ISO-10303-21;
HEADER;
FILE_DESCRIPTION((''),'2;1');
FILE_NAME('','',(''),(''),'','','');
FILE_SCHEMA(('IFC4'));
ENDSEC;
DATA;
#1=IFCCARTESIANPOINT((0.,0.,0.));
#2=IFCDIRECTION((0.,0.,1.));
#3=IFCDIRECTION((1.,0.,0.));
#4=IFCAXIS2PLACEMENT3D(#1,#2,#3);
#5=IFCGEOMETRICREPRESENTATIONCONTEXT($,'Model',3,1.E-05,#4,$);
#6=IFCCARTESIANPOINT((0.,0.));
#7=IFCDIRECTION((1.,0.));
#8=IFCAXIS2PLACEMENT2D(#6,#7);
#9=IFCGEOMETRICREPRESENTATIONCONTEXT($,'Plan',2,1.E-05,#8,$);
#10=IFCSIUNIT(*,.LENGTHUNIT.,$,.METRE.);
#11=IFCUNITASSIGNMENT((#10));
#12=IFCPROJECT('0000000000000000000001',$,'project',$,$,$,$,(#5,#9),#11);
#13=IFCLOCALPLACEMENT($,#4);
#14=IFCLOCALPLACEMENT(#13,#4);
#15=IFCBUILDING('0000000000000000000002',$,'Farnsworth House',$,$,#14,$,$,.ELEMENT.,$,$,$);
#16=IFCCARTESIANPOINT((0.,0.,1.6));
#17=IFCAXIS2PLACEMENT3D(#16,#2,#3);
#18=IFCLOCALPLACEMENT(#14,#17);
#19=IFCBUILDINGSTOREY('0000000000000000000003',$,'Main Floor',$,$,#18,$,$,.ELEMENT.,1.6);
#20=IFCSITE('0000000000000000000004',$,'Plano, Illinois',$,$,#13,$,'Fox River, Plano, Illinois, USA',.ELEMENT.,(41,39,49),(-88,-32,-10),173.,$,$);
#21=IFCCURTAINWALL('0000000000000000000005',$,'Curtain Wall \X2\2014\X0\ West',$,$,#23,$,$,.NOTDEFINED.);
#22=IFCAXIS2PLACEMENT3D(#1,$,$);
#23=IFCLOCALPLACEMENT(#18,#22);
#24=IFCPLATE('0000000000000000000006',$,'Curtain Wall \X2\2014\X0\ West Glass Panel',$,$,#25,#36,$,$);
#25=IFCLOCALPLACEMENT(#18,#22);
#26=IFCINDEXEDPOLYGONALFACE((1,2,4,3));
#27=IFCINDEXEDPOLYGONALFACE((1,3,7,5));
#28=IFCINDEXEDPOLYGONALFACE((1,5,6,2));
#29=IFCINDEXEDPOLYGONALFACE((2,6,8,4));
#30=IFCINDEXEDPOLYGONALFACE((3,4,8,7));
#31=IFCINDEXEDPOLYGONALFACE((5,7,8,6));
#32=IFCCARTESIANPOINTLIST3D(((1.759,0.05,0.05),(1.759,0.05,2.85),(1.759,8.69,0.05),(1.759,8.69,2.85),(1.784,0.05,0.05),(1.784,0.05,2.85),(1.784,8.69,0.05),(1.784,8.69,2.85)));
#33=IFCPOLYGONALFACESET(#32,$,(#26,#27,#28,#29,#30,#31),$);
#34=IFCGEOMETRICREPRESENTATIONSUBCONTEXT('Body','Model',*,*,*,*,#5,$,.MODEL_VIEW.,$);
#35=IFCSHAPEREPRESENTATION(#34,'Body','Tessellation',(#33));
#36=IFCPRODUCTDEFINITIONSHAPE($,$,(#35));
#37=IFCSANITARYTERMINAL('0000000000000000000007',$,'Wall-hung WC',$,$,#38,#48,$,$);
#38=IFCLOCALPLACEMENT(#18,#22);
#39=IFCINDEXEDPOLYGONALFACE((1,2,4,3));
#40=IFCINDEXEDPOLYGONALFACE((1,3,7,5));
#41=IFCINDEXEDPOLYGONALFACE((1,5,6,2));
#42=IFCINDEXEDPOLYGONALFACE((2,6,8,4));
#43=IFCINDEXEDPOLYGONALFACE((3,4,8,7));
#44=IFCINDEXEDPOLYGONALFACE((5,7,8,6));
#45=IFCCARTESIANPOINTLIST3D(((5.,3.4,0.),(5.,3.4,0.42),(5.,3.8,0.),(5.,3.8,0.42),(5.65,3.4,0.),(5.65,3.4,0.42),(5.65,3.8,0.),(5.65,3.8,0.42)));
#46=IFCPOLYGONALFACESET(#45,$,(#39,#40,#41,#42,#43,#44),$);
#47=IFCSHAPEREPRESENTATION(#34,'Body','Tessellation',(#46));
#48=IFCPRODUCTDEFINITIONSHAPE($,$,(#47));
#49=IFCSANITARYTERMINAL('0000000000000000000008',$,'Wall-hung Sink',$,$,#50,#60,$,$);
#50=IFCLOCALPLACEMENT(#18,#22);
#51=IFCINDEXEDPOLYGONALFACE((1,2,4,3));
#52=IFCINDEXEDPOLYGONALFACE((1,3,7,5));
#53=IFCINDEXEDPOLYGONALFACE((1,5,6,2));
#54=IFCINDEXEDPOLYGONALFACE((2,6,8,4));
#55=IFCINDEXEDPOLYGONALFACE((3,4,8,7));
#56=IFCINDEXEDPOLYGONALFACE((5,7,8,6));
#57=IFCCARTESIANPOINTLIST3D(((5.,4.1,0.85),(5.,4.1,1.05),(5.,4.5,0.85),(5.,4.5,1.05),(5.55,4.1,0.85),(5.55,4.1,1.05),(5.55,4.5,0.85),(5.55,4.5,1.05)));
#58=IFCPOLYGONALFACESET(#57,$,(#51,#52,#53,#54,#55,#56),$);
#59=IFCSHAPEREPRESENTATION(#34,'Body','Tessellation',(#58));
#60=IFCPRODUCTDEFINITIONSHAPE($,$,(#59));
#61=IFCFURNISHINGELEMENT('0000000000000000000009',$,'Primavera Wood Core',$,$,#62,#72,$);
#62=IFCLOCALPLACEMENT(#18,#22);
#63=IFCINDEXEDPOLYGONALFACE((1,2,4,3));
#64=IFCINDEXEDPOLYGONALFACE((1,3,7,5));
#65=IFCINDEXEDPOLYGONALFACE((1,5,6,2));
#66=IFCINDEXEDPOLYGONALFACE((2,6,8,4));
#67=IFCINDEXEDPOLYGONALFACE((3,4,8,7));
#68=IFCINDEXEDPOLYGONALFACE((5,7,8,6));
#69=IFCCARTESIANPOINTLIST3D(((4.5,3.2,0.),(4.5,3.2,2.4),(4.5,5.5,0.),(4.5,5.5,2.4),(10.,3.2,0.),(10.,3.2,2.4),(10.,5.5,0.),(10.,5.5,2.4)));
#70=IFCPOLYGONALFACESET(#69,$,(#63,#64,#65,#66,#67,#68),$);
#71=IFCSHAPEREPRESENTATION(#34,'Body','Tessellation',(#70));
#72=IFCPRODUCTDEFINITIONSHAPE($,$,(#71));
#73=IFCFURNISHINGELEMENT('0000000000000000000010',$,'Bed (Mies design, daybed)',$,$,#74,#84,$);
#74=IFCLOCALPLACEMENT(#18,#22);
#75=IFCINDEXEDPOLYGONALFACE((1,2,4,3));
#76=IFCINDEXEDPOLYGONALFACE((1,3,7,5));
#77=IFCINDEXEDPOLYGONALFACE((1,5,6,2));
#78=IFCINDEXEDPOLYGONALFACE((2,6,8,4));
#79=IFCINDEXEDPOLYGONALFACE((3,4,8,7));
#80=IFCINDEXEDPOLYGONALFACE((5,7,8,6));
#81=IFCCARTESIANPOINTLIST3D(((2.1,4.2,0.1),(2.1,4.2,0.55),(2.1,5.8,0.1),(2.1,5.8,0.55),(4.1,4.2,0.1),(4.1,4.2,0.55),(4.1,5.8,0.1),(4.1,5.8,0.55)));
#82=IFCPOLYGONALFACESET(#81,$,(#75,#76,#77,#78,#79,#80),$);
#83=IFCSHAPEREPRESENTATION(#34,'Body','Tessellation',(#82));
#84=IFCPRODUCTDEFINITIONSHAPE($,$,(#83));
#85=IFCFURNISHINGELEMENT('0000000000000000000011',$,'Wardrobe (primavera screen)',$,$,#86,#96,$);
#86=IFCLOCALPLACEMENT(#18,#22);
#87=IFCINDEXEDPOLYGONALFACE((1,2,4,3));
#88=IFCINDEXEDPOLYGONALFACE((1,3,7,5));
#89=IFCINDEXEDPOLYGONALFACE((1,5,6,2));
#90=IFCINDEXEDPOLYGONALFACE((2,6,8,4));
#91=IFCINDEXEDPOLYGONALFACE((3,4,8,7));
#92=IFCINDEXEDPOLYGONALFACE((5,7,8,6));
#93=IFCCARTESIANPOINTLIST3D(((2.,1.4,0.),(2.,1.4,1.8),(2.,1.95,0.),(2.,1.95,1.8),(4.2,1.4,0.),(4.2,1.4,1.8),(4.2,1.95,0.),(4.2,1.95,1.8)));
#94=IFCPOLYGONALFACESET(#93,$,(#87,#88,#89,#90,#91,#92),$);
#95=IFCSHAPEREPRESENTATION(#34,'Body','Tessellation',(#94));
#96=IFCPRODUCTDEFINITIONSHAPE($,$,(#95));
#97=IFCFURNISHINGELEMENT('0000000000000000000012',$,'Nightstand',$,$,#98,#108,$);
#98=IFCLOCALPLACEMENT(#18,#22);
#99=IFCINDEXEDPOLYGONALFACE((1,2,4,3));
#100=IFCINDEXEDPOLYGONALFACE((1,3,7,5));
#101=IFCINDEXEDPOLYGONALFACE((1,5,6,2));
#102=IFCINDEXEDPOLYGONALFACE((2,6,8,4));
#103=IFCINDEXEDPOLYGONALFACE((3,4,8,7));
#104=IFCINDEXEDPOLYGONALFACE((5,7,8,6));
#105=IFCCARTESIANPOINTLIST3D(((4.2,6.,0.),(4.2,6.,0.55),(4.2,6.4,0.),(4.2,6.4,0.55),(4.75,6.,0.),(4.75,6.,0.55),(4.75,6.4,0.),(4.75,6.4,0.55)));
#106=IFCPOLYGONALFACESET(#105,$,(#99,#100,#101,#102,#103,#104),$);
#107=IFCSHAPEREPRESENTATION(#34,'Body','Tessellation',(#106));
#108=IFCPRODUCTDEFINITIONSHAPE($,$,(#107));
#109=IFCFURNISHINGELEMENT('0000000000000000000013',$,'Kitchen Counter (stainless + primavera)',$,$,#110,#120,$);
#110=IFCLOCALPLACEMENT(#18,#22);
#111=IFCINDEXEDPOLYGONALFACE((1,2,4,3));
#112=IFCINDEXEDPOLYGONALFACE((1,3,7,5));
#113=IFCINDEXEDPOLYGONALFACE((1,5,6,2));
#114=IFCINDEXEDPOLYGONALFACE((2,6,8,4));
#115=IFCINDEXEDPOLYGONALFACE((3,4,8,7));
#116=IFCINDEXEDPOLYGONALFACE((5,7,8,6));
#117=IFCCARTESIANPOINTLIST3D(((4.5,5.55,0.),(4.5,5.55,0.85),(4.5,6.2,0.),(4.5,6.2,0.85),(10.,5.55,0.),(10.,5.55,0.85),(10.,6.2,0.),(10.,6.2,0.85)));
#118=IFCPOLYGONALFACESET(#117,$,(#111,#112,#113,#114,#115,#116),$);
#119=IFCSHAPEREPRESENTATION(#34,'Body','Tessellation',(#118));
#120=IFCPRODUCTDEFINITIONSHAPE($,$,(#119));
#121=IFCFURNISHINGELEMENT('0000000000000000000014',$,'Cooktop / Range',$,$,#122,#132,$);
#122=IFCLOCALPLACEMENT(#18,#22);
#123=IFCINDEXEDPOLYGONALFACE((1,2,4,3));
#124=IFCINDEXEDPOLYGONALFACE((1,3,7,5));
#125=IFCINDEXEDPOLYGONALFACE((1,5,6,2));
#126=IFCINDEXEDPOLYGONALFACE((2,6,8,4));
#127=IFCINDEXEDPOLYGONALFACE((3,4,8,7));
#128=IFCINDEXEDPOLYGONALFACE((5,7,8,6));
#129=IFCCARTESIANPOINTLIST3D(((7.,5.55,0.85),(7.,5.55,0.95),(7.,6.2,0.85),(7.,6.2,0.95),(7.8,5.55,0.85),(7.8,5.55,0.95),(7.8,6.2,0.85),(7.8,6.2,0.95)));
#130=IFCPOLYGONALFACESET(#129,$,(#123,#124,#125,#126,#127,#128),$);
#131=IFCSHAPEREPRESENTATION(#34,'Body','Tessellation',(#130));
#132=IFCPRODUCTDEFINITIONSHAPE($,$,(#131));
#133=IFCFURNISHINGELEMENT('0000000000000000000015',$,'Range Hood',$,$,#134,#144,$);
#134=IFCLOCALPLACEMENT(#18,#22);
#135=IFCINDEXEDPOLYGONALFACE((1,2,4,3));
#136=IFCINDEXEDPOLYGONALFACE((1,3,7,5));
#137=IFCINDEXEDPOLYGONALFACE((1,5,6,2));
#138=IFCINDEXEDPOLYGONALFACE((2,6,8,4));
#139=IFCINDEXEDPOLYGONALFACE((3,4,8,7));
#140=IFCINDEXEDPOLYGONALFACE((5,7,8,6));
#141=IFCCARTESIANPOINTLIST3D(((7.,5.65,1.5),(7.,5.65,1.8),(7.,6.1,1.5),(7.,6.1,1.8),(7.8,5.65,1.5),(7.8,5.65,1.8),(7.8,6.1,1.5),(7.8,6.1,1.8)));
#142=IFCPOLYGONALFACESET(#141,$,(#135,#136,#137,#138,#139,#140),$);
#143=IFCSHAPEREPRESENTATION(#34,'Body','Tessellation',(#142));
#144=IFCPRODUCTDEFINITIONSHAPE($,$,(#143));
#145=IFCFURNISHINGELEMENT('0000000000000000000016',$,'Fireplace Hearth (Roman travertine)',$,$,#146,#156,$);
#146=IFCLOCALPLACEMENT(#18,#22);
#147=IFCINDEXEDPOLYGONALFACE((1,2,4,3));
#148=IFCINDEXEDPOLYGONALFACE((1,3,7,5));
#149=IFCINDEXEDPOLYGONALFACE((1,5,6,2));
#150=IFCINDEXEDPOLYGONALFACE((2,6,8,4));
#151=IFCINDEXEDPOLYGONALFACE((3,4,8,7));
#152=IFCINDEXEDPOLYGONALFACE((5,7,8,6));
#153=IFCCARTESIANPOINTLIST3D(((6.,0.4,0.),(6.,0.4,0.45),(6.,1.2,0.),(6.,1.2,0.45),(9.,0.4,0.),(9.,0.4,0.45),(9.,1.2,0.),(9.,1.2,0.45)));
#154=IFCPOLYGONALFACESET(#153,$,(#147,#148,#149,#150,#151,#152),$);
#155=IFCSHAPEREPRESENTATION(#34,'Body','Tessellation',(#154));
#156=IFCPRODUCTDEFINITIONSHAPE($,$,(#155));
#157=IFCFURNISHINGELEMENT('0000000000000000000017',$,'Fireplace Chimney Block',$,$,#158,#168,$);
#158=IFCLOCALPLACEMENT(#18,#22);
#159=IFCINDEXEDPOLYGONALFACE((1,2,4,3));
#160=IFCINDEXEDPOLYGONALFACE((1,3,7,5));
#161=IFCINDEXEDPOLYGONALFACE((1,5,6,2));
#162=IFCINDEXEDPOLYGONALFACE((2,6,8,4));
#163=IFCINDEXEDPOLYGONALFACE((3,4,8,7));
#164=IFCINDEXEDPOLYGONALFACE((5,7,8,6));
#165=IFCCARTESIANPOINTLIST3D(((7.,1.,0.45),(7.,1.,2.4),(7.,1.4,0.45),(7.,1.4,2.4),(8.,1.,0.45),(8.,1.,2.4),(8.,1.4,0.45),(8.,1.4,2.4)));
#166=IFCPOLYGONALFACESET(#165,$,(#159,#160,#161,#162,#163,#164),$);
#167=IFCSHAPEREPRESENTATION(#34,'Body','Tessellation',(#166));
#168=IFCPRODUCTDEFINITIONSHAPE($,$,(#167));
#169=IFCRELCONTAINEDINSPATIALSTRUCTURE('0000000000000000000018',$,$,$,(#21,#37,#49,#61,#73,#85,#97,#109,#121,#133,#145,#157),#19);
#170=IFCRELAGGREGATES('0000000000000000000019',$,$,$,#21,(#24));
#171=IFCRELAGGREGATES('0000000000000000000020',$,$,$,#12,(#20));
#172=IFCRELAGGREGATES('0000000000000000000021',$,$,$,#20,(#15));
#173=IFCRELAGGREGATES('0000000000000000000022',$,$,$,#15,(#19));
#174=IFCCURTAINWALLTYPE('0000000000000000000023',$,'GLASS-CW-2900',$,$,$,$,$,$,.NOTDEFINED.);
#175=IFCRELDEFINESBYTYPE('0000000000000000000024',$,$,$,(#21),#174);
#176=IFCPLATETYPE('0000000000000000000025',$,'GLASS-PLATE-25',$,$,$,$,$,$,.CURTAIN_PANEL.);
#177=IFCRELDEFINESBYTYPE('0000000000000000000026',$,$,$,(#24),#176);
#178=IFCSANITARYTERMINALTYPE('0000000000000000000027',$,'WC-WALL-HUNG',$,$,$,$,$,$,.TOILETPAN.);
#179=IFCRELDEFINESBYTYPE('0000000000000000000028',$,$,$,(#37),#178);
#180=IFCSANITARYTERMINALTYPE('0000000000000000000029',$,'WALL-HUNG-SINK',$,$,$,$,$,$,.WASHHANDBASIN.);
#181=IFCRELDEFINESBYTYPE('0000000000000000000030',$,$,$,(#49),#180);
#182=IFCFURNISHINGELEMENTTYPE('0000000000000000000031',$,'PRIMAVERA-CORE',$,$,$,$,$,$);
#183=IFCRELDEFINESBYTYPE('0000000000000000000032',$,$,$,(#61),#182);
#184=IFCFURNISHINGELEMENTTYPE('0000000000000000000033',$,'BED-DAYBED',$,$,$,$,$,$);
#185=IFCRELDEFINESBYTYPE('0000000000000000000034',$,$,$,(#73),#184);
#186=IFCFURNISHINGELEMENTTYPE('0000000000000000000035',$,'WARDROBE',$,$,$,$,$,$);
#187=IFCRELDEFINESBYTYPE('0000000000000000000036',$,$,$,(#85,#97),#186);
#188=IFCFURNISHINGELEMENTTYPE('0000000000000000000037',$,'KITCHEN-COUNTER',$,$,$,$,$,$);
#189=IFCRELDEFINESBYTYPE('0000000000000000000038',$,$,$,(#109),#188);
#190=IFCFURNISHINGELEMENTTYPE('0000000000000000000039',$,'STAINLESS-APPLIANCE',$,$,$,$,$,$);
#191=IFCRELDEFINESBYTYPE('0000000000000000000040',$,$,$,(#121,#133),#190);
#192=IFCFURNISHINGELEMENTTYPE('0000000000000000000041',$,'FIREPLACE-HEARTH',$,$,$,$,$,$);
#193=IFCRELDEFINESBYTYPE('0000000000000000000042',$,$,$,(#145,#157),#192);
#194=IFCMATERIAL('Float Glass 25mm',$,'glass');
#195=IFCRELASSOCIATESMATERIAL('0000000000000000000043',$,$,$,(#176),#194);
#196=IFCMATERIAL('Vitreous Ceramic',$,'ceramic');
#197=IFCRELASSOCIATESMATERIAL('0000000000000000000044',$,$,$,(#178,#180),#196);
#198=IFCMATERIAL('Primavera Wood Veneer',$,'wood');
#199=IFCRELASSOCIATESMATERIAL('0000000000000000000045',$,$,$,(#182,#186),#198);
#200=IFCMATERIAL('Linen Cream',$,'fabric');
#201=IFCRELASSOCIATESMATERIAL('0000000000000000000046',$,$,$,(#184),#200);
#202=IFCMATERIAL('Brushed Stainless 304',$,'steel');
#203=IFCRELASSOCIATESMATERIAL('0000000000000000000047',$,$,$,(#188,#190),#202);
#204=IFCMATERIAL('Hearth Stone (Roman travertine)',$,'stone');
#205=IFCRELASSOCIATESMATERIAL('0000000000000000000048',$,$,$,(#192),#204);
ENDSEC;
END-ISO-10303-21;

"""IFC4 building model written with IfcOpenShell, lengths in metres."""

from ifc_helpers import new_model, si_unit, frame, origin_with_axes, origin_2d_with_axis, place, context, subcontext, project, spatial, rectangle, extrude, material, type_object, element, aggregate, save


model = new_model("IFC4")

# Units and contexts
model_context = context("Model", 3, precision=1e-05, world=origin_with_axes())
plan_context = context("Plan", 2, precision=1e-05, world=origin_2d_with_axis())
body_context = subcontext(model_context, "Body", "Model", "MODEL_VIEW")
ifc_project = project(units=[si_unit("LENGTHUNIT", "METRE")], contexts=[model_context, plan_context])

# Site, building, storey
site_placement = place(None, origin_with_axes())
site = spatial("IfcSite", under=ifc_project, at=site_placement, Name="Plano, Illinois", LongName="Fox River, Plano, Illinois, USA", CompositionType="ELEMENT", RefLatitude=(41, 39, 49), RefLongitude=(-88, -32, -10), RefElevation=173.0)
building_placement = place(site_placement, origin_with_axes())
building = spatial("IfcBuilding", under=site, at=building_placement, Name="Farnsworth House", CompositionType="ELEMENT")
storey_placement = place(building_placement, frame((0.0, 0.0, 1.6), z_axis=(0.0, 0.0, 1.0), x_axis=(1.0, 0.0, 0.0)))
storey = spatial("IfcBuildingStorey", under=building, at=storey_placement, Name="Main Floor", CompositionType="ELEMENT", Elevation=1.6)

# Curtain wall
curtain_wall_type = type_object("IfcCurtainWallType", Name="GLASS-CW-2900", PredefinedType="NOTDEFINED")
curtain_wall_1_placement = place(storey_placement, frame((1.7839, 0.0, 0.0), z_axis=(0.0, 0.0, 1.0), x_axis=(0.0, 1.0, 0.0)))
curtain_wall_1 = element("IfcCurtainWall", 1, at=curtain_wall_1_placement, inside=storey, type_object=curtain_wall_type, Name="Curtain Wall — West", PredefinedType="NOTDEFINED")

# Plate
ifc_material_1 = material(Name="Float Glass 25mm", Category="glass")
plate_type = type_object("IfcPlateType", Name="GLASS-PLATE-25", PredefinedType="CURTAIN_PANEL", material=ifc_material_1)
plate_1_placement = place(curtain_wall_1_placement, frame((0.05, 0.0, 0.05), z_axis=(0.0, 0.0, 1.0), x_axis=(1.0, 0.0, 0.0)))
plate_1 = element("IfcPlate", 2, at=plate_1_placement, type_object=plate_type, Name="Curtain Wall — West Glass Panel", context=body_context, shape_type="SweptSolid", body=[
    extrude(rectangle(XDim=8.64, YDim=0.025, at=origin_2d_with_axis()), frame((4.32, 0.0125, 0.0), z_axis=(0.0, 0.0, 1.0), x_axis=(1.0, 0.0, 0.0)), (0.0, 0.0, 1.0), 2.8),
])
aggregate(curtain_wall_1, [plate_1])

# Sanitary terminals
ifc_material_2 = material(Name="Vitreous Ceramic", Category="ceramic")
sanitary_terminal_type_1 = type_object("IfcSanitaryTerminalType", Name="WC-WALL-HUNG", PredefinedType="TOILETPAN", material=ifc_material_2)
sanitary_terminal_1_placement = place(storey_placement, frame((5.0, 3.4, 0.0), z_axis=(0.0, 0.0, 1.0), x_axis=(1.0, 0.0, 0.0)))
element("IfcSanitaryTerminal", 3, at=sanitary_terminal_1_placement, inside=storey, type_object=sanitary_terminal_type_1, Name="Wall-hung WC", context=body_context, shape_type="SweptSolid", body=[
    extrude(rectangle(XDim=0.65, YDim=0.4, at=origin_2d_with_axis()), frame((0.325, 0.2, 0.0), z_axis=(0.0, 0.0, 1.0), x_axis=(1.0, 0.0, 0.0)), (0.0, 0.0, 1.0), 0.42),
])
sanitary_terminal_type_2 = type_object("IfcSanitaryTerminalType", Name="WALL-HUNG-SINK", PredefinedType="WASHHANDBASIN", material=ifc_material_2)
sanitary_terminal_2_placement = place(storey_placement, frame((5.0, 4.1, 0.85), z_axis=(0.0, 0.0, 1.0), x_axis=(1.0, 0.0, 0.0)))
element("IfcSanitaryTerminal", 4, at=sanitary_terminal_2_placement, inside=storey, type_object=sanitary_terminal_type_2, Name="Wall-hung Sink", context=body_context, shape_type="SweptSolid", body=[
    extrude(rectangle(XDim=0.55, YDim=0.4, at=origin_2d_with_axis()), frame((0.275, 0.2, 0.0), z_axis=(0.0, 0.0, 1.0), x_axis=(1.0, 0.0, 0.0)), (0.0, 0.0, 1.0), 0.2),
])

# Furnishing elements
ifc_material_3 = material(Name="Primavera Wood Veneer", Category="wood")
furnishing_element_type_1 = type_object("IfcFurnishingElementType", Name="PRIMAVERA-CORE", material=ifc_material_3)
furnishing_1_placement = place(storey_placement, frame((4.5, 3.2, 0.0), z_axis=(0.0, 0.0, 1.0), x_axis=(1.0, 0.0, 0.0)))
element("IfcFurnishingElement", 5, at=furnishing_1_placement, inside=storey, type_object=furnishing_element_type_1, Name="Primavera Wood Core", context=body_context, shape_type="SweptSolid", body=[
    extrude(rectangle(XDim=5.5, YDim=2.3, at=origin_2d_with_axis()), frame((2.75, 1.15, 0.0), z_axis=(0.0, 0.0, 1.0), x_axis=(1.0, 0.0, 0.0)), (0.0, 0.0, 1.0), 2.4),
])
ifc_material_4 = material(Name="Linen Cream", Category="fabric")
furnishing_element_type_2 = type_object("IfcFurnishingElementType", Name="BED-DAYBED", material=ifc_material_4)
furnishing_2_placement = place(storey_placement, frame((2.1, 4.2, 0.1), z_axis=(0.0, 0.0, 1.0), x_axis=(1.0, 0.0, 0.0)))
element("IfcFurnishingElement", 6, at=furnishing_2_placement, inside=storey, type_object=furnishing_element_type_2, Name="Bed (Mies design, daybed)", context=body_context, shape_type="SweptSolid", body=[
    extrude(rectangle(XDim=2.0, YDim=1.6, at=origin_2d_with_axis()), frame((1.0, 0.8, 0.0), z_axis=(0.0, 0.0, 1.0), x_axis=(1.0, 0.0, 0.0)), (0.0, 0.0, 1.0), 0.45),
])
furnishing_element_type_3 = type_object("IfcFurnishingElementType", Name="WARDROBE", material=ifc_material_3)
furnishing_3_placement = place(storey_placement, frame((2.0, 1.4, 0.0), z_axis=(0.0, 0.0, 1.0), x_axis=(1.0, 0.0, 0.0)))
element("IfcFurnishingElement", 7, at=furnishing_3_placement, inside=storey, type_object=furnishing_element_type_3, Name="Wardrobe (primavera screen)", context=body_context, shape_type="SweptSolid", body=[
    extrude(rectangle(XDim=2.2, YDim=0.55, at=origin_2d_with_axis()), frame((1.1, 0.275, 0.0), z_axis=(0.0, 0.0, 1.0), x_axis=(1.0, 0.0, 0.0)), (0.0, 0.0, 1.0), 1.8),
])
furnishing_4_placement = place(storey_placement, frame((4.2, 6.0, 0.0), z_axis=(0.0, 0.0, 1.0), x_axis=(1.0, 0.0, 0.0)))
element("IfcFurnishingElement", 8, at=furnishing_4_placement, inside=storey, type_object=furnishing_element_type_3, Name="Nightstand", context=body_context, shape_type="SweptSolid", body=[
    extrude(rectangle(XDim=0.55, YDim=0.4, at=origin_2d_with_axis()), frame((0.275, 0.2, 0.0), z_axis=(0.0, 0.0, 1.0), x_axis=(1.0, 0.0, 0.0)), (0.0, 0.0, 1.0), 0.55),
])
ifc_material_5 = material(Name="Brushed Stainless 304", Category="steel")
furnishing_element_type_4 = type_object("IfcFurnishingElementType", Name="KITCHEN-COUNTER", material=ifc_material_5)
furnishing_5_placement = place(storey_placement, frame((4.5, 5.55, 0.0), z_axis=(0.0, 0.0, 1.0), x_axis=(1.0, 0.0, 0.0)))
element("IfcFurnishingElement", 9, at=furnishing_5_placement, inside=storey, type_object=furnishing_element_type_4, Name="Kitchen Counter (stainless + primavera)", context=body_context, shape_type="SweptSolid", body=[
    extrude(rectangle(XDim=5.5, YDim=0.65, at=origin_2d_with_axis()), frame((2.75, 0.325, 0.0), z_axis=(0.0, 0.0, 1.0), x_axis=(1.0, 0.0, 0.0)), (0.0, 0.0, 1.0), 0.85),
])
furnishing_element_type_5 = type_object("IfcFurnishingElementType", Name="STAINLESS-APPLIANCE", material=ifc_material_5)
furnishing_6_placement = place(storey_placement, frame((7.0, 5.55, 0.85), z_axis=(0.0, 0.0, 1.0), x_axis=(1.0, 0.0, 0.0)))
element("IfcFurnishingElement", 10, at=furnishing_6_placement, inside=storey, type_object=furnishing_element_type_5, Name="Cooktop / Range", context=body_context, shape_type="SweptSolid", body=[
    extrude(rectangle(XDim=0.8, YDim=0.65, at=origin_2d_with_axis()), frame((0.4, 0.325, 0.0), z_axis=(0.0, 0.0, 1.0), x_axis=(1.0, 0.0, 0.0)), (0.0, 0.0, 1.0), 0.1),
])
furnishing_7_placement = place(storey_placement, frame((7.0, 5.65, 1.5), z_axis=(0.0, 0.0, 1.0), x_axis=(1.0, 0.0, 0.0)))
element("IfcFurnishingElement", 11, at=furnishing_7_placement, inside=storey, type_object=furnishing_element_type_5, Name="Range Hood", context=body_context, shape_type="SweptSolid", body=[
    extrude(rectangle(XDim=0.8, YDim=0.45, at=origin_2d_with_axis()), frame((0.4, 0.225, 0.0), z_axis=(0.0, 0.0, 1.0), x_axis=(1.0, 0.0, 0.0)), (0.0, 0.0, 1.0), 0.3),
])
ifc_material_6 = material(Name="Hearth Stone (Roman travertine)", Category="stone")
furnishing_element_type_6 = type_object("IfcFurnishingElementType", Name="FIREPLACE-HEARTH", material=ifc_material_6)
furnishing_8_placement = place(storey_placement, frame((6.0, 0.4, 0.0), z_axis=(0.0, 0.0, 1.0), x_axis=(1.0, 0.0, 0.0)))
element("IfcFurnishingElement", 12, at=furnishing_8_placement, inside=storey, type_object=furnishing_element_type_6, Name="Fireplace Hearth (Roman travertine)", context=body_context, shape_type="SweptSolid", body=[
    extrude(rectangle(XDim=3.0, YDim=0.8, at=origin_2d_with_axis()), frame((1.5, 0.4, 0.0), z_axis=(0.0, 0.0, 1.0), x_axis=(1.0, 0.0, 0.0)), (0.0, 0.0, 1.0), 0.45),
])
furnishing_9_placement = place(storey_placement, frame((7.0, 1.0, 0.45), z_axis=(0.0, 0.0, 1.0), x_axis=(1.0, 0.0, 0.0)))
element("IfcFurnishingElement", 13, at=furnishing_9_placement, inside=storey, type_object=furnishing_element_type_6, Name="Fireplace Chimney Block", context=body_context, shape_type="SweptSolid", body=[
    extrude(rectangle(XDim=1.0, YDim=0.4, at=origin_2d_with_axis()), frame((0.5, 0.2, 0.0), z_axis=(0.0, 0.0, 1.0), x_axis=(1.0, 0.0, 0.0)), (0.0, 0.0, 1.0), 1.95),
])

save(model, "model.ifc")
